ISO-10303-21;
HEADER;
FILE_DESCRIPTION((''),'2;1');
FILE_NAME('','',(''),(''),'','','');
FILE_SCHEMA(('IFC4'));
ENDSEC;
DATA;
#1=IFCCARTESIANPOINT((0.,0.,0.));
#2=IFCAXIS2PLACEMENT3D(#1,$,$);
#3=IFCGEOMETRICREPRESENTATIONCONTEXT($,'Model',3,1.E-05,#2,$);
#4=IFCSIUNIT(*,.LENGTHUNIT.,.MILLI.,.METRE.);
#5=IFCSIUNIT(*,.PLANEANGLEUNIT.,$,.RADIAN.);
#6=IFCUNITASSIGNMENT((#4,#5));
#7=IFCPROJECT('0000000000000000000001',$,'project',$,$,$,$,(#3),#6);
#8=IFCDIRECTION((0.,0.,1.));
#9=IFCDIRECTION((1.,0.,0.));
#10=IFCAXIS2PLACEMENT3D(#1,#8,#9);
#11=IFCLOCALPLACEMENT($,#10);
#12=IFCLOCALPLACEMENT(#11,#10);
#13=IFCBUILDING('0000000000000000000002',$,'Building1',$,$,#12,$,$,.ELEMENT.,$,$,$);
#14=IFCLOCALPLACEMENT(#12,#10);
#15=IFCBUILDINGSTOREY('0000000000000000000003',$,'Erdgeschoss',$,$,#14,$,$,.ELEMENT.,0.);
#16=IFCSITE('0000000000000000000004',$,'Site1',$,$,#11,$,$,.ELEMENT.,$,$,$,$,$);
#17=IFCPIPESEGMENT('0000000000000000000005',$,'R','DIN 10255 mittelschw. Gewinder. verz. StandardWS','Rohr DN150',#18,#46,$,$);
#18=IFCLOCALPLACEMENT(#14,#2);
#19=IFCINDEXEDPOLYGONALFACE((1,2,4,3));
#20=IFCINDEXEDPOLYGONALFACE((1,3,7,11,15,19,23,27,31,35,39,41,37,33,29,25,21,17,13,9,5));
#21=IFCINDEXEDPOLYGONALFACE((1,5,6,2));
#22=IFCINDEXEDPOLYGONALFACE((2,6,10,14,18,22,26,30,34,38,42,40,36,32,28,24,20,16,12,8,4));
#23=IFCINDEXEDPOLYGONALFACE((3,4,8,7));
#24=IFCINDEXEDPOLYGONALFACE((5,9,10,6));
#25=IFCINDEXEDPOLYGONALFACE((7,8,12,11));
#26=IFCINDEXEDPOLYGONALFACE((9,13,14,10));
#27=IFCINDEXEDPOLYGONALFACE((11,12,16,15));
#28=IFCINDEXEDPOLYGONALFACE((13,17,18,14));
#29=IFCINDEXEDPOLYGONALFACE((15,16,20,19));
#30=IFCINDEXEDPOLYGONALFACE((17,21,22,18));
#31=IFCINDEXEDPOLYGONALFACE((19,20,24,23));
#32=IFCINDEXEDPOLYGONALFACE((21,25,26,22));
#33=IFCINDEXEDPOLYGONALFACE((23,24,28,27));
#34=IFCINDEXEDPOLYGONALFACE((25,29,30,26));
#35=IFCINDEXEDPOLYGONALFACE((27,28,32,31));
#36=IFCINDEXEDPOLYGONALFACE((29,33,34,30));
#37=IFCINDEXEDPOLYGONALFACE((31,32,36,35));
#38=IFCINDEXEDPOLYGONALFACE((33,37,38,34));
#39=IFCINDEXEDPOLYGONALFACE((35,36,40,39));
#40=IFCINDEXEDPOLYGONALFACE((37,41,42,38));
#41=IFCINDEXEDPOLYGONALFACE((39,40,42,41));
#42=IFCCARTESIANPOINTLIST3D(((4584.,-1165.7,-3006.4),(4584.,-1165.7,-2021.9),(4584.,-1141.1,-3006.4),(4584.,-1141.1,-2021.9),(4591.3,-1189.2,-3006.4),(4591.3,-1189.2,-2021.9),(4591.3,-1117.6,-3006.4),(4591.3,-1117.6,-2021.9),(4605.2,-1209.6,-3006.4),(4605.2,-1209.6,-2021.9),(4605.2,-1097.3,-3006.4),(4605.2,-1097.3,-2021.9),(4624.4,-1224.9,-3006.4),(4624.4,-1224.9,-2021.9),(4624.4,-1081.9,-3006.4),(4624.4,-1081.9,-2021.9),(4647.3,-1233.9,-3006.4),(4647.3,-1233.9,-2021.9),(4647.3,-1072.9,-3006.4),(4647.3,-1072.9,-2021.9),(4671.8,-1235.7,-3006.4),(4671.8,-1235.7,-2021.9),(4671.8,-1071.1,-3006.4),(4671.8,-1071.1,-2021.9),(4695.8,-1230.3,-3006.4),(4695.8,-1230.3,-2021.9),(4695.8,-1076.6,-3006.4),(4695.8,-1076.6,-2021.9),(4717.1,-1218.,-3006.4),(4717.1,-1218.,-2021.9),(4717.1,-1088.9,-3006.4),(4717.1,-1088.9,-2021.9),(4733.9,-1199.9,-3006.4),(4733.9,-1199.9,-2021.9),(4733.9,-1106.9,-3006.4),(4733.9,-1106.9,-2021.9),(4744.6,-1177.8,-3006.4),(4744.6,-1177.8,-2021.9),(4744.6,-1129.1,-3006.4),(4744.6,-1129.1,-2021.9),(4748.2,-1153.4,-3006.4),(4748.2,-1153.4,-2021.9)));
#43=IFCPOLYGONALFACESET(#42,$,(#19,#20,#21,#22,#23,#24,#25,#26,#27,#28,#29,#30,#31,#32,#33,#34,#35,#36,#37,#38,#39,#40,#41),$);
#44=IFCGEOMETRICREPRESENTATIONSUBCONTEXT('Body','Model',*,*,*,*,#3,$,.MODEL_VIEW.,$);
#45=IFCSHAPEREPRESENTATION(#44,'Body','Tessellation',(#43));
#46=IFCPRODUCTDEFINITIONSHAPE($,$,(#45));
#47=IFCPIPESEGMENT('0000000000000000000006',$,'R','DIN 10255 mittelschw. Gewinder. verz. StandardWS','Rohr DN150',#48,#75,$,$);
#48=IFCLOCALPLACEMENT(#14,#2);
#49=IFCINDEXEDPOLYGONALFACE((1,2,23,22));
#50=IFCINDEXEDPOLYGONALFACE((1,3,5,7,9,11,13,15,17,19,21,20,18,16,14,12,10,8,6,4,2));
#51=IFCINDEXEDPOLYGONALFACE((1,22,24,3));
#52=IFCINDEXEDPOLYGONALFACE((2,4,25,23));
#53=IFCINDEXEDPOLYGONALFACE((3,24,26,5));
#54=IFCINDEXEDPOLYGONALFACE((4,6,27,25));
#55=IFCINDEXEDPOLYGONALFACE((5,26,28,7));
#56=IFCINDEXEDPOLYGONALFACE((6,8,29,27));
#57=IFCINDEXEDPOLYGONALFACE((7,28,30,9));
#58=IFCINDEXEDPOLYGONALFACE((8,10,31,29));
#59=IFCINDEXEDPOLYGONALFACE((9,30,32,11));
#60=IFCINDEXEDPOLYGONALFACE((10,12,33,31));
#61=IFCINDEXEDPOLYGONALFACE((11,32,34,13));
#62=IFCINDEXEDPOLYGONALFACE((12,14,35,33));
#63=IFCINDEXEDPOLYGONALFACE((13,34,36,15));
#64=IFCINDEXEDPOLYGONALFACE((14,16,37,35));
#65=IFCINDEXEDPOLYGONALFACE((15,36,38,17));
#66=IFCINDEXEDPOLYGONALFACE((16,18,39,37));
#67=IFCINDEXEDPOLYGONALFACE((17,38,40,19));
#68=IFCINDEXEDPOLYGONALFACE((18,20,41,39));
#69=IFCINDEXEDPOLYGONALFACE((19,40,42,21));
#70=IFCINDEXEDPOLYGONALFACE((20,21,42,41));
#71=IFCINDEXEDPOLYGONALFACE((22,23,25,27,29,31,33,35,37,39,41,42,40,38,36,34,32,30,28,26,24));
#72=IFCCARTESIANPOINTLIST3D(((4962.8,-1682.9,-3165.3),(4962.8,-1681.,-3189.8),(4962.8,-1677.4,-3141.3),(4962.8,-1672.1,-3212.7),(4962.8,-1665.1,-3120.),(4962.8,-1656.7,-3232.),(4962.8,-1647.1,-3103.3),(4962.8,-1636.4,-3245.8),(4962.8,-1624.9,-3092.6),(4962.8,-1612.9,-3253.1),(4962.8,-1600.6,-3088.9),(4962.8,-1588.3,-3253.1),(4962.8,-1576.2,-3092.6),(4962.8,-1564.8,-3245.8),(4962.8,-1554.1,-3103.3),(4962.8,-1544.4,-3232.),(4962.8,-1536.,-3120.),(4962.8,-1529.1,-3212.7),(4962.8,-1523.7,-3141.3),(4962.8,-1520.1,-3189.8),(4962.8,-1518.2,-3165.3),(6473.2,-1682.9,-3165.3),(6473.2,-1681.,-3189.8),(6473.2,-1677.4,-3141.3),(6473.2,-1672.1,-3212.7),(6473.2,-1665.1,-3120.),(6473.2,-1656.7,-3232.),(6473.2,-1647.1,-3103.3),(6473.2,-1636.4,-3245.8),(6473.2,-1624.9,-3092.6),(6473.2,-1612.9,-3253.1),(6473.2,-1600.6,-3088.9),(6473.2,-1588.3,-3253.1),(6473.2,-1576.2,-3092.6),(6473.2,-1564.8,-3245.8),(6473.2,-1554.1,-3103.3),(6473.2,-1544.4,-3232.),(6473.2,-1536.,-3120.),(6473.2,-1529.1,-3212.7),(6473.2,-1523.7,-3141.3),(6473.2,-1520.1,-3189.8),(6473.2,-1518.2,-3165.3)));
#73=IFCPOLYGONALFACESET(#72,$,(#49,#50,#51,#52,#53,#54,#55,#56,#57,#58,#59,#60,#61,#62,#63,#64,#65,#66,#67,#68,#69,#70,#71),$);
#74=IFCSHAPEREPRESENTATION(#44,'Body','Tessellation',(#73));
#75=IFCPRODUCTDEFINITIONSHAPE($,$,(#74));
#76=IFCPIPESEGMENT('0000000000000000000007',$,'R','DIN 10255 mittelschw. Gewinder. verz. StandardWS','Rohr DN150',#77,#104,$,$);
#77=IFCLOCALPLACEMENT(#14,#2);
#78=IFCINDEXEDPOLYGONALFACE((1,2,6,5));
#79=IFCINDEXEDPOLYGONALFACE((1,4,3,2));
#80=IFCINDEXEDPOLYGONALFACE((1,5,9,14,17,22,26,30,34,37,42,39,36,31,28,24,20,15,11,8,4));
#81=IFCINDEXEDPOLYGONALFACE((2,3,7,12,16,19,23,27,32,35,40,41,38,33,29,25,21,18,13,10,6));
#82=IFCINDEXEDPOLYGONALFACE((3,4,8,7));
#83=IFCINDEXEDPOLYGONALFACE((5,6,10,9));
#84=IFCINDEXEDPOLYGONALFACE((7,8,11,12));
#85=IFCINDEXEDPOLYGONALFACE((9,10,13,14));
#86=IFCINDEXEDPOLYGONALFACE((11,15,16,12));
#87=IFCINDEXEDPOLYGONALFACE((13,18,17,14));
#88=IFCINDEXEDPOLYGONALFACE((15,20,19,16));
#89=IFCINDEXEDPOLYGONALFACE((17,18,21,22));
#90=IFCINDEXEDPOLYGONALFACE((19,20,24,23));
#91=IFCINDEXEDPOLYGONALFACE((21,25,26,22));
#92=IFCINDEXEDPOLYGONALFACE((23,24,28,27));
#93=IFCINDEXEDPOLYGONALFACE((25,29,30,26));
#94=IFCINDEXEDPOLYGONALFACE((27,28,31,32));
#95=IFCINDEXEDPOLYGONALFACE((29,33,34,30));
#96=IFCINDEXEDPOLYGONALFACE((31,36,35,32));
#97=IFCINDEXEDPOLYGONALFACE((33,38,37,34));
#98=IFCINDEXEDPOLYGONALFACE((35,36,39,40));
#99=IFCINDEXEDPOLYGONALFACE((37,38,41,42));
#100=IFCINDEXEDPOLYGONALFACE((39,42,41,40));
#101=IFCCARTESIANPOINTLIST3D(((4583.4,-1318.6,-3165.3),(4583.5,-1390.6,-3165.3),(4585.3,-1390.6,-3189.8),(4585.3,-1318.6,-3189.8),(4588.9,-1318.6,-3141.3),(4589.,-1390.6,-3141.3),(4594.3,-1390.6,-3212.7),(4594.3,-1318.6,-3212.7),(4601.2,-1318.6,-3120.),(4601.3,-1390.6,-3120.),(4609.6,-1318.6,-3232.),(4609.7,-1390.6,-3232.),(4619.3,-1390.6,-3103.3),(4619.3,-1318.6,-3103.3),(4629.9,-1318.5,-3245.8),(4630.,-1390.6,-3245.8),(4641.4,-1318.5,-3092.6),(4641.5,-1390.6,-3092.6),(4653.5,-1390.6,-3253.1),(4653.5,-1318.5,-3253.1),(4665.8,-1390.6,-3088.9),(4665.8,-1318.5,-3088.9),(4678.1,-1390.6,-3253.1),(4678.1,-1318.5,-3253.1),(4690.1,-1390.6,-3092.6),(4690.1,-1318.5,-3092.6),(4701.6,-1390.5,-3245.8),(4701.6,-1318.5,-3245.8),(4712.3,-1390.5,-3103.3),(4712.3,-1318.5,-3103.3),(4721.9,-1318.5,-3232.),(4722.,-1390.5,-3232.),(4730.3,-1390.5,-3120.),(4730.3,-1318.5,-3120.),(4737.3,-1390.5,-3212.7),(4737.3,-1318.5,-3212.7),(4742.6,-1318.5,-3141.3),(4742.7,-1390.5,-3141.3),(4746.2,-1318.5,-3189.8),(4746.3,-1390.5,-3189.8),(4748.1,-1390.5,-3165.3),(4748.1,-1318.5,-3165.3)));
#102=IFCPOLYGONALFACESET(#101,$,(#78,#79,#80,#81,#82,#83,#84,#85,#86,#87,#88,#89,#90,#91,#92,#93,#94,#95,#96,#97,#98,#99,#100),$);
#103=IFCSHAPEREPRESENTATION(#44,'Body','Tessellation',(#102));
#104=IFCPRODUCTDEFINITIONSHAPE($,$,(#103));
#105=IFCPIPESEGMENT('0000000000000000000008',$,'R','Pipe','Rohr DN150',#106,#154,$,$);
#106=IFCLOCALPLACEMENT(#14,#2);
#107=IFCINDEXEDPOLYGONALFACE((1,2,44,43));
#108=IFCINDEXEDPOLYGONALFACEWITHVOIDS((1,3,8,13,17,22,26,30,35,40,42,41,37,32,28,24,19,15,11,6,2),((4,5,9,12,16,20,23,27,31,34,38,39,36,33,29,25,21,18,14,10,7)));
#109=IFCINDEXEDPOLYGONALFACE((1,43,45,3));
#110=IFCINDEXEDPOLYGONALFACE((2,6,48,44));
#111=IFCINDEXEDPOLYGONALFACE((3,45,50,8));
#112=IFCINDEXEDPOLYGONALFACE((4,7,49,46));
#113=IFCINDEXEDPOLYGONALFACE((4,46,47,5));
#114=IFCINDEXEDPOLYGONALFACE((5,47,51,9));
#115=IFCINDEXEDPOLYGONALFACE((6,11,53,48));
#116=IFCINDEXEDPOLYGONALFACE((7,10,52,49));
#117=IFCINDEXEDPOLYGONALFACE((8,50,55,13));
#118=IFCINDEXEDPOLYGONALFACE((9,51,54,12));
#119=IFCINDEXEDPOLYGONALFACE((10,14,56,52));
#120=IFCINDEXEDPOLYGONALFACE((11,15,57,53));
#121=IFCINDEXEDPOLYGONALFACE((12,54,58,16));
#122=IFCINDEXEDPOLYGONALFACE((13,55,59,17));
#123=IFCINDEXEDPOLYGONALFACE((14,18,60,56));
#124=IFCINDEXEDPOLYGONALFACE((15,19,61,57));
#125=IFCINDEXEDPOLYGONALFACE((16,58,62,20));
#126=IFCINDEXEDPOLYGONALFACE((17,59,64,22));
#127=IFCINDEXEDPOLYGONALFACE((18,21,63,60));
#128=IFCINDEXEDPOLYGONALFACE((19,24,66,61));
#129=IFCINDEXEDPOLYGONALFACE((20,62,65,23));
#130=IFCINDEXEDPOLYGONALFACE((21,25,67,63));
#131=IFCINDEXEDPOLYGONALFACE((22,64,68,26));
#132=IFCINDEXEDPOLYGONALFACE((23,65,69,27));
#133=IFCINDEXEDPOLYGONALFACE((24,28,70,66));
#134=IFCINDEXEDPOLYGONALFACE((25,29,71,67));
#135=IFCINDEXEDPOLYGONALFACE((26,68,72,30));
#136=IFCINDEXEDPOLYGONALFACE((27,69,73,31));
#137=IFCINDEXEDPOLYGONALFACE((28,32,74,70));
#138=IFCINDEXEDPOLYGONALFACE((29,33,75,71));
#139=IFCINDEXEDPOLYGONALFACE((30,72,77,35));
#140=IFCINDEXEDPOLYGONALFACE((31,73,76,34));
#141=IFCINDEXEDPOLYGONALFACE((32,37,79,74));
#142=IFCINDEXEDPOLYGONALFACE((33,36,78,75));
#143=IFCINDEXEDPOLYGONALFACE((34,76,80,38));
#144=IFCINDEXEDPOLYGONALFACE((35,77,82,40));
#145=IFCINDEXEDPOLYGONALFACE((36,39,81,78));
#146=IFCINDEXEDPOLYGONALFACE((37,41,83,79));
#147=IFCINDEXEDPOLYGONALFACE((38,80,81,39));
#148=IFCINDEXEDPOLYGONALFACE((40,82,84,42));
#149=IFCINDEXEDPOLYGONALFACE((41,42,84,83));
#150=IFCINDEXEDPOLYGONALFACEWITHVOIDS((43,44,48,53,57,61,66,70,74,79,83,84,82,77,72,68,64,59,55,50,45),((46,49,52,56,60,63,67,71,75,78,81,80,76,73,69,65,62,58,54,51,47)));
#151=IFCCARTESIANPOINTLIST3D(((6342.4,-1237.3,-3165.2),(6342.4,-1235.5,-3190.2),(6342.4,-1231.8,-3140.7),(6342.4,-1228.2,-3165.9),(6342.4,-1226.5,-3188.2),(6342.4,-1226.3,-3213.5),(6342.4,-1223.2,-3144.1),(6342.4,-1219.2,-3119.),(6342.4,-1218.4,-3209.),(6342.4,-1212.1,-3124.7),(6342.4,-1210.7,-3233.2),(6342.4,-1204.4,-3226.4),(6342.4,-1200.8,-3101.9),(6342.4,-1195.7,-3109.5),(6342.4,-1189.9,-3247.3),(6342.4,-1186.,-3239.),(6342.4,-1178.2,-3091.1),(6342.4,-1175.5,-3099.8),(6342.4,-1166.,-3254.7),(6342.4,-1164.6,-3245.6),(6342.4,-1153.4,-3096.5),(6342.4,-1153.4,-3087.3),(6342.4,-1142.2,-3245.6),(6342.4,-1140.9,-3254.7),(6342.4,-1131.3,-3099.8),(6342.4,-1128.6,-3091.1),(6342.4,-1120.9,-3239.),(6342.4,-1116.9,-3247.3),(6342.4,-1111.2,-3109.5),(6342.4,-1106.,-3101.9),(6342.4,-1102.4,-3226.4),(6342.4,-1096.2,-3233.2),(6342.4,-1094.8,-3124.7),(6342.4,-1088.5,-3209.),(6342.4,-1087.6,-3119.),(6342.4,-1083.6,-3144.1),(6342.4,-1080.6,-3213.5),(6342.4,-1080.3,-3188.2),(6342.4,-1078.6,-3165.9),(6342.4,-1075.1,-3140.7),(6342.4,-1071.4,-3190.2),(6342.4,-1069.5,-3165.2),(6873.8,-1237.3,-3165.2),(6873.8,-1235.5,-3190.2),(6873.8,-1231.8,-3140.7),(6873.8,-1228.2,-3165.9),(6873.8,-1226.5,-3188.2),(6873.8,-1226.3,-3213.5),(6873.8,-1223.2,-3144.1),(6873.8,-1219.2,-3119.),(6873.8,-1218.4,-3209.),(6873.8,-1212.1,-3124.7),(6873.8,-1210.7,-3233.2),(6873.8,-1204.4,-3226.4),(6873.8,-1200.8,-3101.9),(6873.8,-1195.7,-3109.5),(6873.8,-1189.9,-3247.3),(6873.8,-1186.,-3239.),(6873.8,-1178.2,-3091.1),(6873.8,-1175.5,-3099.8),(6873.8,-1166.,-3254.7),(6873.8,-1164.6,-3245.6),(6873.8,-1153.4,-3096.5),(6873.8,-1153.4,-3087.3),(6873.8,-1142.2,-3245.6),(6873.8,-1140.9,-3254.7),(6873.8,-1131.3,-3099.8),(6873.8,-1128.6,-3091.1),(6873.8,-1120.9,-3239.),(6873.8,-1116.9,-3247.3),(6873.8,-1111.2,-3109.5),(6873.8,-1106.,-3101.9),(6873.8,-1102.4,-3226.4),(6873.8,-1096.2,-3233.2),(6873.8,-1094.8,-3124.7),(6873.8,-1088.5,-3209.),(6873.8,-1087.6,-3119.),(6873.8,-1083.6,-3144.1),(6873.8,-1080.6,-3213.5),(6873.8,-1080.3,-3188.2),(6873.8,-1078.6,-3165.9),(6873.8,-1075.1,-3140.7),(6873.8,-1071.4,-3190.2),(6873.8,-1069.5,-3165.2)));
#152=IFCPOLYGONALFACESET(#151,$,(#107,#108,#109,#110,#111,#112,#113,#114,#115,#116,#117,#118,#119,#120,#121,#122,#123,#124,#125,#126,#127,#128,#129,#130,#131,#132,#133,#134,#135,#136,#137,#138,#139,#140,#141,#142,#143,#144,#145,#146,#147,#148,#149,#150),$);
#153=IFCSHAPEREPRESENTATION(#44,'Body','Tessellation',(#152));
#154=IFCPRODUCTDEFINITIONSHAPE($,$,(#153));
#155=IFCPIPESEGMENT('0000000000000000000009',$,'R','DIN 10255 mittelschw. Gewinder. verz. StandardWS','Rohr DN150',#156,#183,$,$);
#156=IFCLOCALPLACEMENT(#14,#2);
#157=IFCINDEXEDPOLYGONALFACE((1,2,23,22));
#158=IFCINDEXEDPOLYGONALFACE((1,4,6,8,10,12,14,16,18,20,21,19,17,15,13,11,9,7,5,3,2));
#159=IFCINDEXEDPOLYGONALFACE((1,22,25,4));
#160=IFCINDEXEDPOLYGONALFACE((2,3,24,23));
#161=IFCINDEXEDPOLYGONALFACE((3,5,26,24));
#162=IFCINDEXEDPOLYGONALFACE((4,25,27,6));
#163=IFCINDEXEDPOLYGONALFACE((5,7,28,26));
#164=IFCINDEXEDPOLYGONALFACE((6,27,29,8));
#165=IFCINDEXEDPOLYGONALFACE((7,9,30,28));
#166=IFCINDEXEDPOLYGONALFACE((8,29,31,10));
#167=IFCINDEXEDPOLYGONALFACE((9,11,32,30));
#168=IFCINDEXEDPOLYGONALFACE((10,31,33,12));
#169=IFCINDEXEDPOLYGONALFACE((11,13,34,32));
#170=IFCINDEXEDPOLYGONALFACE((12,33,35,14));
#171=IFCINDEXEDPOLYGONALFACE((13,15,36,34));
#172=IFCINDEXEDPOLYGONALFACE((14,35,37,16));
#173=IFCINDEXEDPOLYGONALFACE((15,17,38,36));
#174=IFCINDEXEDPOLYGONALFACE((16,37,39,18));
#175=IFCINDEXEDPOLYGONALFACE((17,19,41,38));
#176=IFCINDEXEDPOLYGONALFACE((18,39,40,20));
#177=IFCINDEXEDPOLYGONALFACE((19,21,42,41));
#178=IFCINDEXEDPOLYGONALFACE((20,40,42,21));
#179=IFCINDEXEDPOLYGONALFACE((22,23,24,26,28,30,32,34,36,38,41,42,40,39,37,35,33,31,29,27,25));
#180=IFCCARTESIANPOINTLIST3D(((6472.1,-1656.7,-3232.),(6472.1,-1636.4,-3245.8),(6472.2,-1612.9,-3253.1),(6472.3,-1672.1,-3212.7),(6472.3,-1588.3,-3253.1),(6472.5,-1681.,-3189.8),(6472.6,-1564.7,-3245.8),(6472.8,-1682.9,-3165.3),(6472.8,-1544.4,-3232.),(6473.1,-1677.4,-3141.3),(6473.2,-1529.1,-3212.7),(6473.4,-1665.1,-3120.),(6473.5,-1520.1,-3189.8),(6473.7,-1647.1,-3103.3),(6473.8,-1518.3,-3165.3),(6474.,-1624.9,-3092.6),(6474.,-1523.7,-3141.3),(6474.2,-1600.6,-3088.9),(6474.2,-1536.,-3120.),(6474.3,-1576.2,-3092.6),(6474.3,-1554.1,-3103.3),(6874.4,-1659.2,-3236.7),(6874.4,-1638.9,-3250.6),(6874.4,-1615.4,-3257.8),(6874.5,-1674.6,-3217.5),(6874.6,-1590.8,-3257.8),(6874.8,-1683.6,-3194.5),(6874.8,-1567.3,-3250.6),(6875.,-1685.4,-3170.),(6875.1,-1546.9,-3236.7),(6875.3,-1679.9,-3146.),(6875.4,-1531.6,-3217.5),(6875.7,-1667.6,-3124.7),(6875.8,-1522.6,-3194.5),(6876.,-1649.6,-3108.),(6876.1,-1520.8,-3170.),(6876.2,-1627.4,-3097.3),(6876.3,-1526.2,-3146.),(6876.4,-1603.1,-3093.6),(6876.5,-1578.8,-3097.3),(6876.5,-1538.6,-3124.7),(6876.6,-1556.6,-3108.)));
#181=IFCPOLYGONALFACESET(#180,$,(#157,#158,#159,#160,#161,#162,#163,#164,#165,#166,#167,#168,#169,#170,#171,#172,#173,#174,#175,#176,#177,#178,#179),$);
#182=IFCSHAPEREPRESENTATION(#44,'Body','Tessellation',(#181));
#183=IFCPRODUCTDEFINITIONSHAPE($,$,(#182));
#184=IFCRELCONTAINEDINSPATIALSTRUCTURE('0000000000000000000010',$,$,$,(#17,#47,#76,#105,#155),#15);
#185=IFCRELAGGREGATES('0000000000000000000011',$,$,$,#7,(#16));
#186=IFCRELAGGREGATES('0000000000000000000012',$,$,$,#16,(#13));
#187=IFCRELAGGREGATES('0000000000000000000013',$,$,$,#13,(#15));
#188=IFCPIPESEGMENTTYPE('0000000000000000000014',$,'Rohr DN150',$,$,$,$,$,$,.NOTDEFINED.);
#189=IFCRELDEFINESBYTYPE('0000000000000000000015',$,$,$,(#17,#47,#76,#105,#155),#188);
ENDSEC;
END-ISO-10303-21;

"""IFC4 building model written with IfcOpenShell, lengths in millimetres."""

from ifc_helpers import new_model, si_unit, frame, origin, origin_with_axes, origin_2d_with_axis, place, context, subcontext, project, spatial, circle, hollow_circle, extrude, type_object, element, save


model = new_model("IFC4")

# Units and contexts
model_context = context("Model", 3, precision=1e-05, world=origin())
body_context = subcontext(model_context, "Body", "Model", "MODEL_VIEW")
ifc_project = project(units=[si_unit("LENGTHUNIT", "METRE", prefix="MILLI"), si_unit("PLANEANGLEUNIT", "RADIAN")], contexts=[model_context])

# Site, building, storey
site_placement = place(None, origin_with_axes())
site = spatial("IfcSite", under=ifc_project, at=site_placement, Name="Site1", CompositionType="ELEMENT")
building_placement = place(site_placement, origin_with_axes())
building = spatial("IfcBuilding", under=site, at=building_placement, Name="Building1", CompositionType="ELEMENT")
storey_placement = place(building_placement, origin_with_axes())
storey = spatial("IfcBuildingStorey", under=building, at=storey_placement, Name="Erdgeschoss", CompositionType="ELEMENT", Elevation=0.0)

# Pipe segments
pipe_segment_type_1 = type_object("IfcPipeSegmentType", Name="Rohr DN150", PredefinedType="NOTDEFINED")
pipe_segment_1_placement = place(storey_placement, frame((4665.7, -1153.6, -2514.1), z_axis=(0.0, 0.0, 1.0), x_axis=(1.0, 0.0, 0.0)))
element("IfcPipeSegment", 1, at=pipe_segment_1_placement, inside=storey, type_object=pipe_segment_type_1, Name="R", Description="DIN 10255 mittelschw. Gewinder. verz. StandardWS", ObjectType="Rohr DN150", context=body_context, shape_type="SolidModel", body=[
    extrude(circle(Radius=82.5, at=origin_2d_with_axis()), frame((0.0, 0.2, -492.3), z_axis=(0.0, 0.0, 1.0), x_axis=(1.0, 0.0, 0.0)), (0.0, 0.0, 1.0), 984.5),
])
pipe_segment_2_placement = place(storey_placement, frame((5718.0, -1600.7, -3171.5), z_axis=(0.0, 0.0, 1.0), x_axis=(1.0, 0.0, 0.0)))
element("IfcPipeSegment", 2, at=pipe_segment_2_placement, inside=storey, type_object=pipe_segment_type_1, Name="R", Description="DIN 10255 mittelschw. Gewinder. verz. StandardWS", ObjectType="Rohr DN150", context=body_context, shape_type="SolidModel", body=[
    extrude(circle(Radius=82.5, at=origin_2d_with_axis()), frame((755.2, 0.1, 0.0), z_axis=(-1.0, 0.0, 0.0), x_axis=(0.0, 0.0, 1.0)), (0.0, 0.0, 1.0), 1510.4),
])
pipe_segment_3_placement = place(storey_placement, frame((4665.6, -1354.5, -3171.5), z_axis=(0.0, 0.0, 1.0), x_axis=(1.0, 0.0, 0.0)))
element("IfcPipeSegment", 3, at=pipe_segment_3_placement, inside=storey, type_object=pipe_segment_type_1, Name="R", Description="DIN 10255 mittelschw. Gewinder. verz. StandardWS", ObjectType="Rohr DN150", context=body_context, shape_type="SolidModel", body=[
    extrude(circle(Radius=82.5, at=origin_2d_with_axis()), frame((0.2, -36.0, 0.0), z_axis=(-0.000562, 1.0, 0.0), x_axis=(0.0, 0.0, 1.0)), (0.0, 0.0, 1.0), 72.0),
])
pipe_segment_4_placement = place(storey_placement, frame((6608.1, -1153.6, -3171.5), z_axis=(0.0, 0.0, 1.0), x_axis=(1.0, 0.0, 0.0)))
element("IfcPipeSegment", 4, at=pipe_segment_4_placement, inside=storey, type_object=pipe_segment_type_1, Name="R", Description="Pipe", ObjectType="Rohr DN150", context=body_context, shape_type="SolidModel", body=[
    extrude(hollow_circle(Radius=84.2, WallThickness=9.2, at=origin_2d_with_axis()), frame((265.7, 0.1, 0.0), z_axis=(-1.0, 0.0, 0.0), x_axis=(0.0, 0.0, 1.0)), (0.0, 0.0, 1.0), 531.3),
])
pipe_segment_5_placement = place(storey_placement, frame((6674.3, -1602.0, -3173.8), z_axis=(0.0, 0.0, 1.0), x_axis=(1.0, 0.0, 0.0)))
element("IfcPipeSegment", 5, at=pipe_segment_5_placement, inside=storey, type_object=pipe_segment_type_1, Name="R", Description="DIN 10255 mittelschw. Gewinder. verz. StandardWS", ObjectType="Rohr DN150", context=body_context, shape_type="SolidModel", body=[
    extrude(circle(Radius=82.5, at=origin_2d_with_axis()), frame((201.1, -1.1, -2.4), z_axis=(-0.999912, 0.00627, 0.011706), x_axis=(0.0, 0.0, 1.0)), (0.0, 0.0, 1.0), 402.3),
])

save(model, "model.ifc")
